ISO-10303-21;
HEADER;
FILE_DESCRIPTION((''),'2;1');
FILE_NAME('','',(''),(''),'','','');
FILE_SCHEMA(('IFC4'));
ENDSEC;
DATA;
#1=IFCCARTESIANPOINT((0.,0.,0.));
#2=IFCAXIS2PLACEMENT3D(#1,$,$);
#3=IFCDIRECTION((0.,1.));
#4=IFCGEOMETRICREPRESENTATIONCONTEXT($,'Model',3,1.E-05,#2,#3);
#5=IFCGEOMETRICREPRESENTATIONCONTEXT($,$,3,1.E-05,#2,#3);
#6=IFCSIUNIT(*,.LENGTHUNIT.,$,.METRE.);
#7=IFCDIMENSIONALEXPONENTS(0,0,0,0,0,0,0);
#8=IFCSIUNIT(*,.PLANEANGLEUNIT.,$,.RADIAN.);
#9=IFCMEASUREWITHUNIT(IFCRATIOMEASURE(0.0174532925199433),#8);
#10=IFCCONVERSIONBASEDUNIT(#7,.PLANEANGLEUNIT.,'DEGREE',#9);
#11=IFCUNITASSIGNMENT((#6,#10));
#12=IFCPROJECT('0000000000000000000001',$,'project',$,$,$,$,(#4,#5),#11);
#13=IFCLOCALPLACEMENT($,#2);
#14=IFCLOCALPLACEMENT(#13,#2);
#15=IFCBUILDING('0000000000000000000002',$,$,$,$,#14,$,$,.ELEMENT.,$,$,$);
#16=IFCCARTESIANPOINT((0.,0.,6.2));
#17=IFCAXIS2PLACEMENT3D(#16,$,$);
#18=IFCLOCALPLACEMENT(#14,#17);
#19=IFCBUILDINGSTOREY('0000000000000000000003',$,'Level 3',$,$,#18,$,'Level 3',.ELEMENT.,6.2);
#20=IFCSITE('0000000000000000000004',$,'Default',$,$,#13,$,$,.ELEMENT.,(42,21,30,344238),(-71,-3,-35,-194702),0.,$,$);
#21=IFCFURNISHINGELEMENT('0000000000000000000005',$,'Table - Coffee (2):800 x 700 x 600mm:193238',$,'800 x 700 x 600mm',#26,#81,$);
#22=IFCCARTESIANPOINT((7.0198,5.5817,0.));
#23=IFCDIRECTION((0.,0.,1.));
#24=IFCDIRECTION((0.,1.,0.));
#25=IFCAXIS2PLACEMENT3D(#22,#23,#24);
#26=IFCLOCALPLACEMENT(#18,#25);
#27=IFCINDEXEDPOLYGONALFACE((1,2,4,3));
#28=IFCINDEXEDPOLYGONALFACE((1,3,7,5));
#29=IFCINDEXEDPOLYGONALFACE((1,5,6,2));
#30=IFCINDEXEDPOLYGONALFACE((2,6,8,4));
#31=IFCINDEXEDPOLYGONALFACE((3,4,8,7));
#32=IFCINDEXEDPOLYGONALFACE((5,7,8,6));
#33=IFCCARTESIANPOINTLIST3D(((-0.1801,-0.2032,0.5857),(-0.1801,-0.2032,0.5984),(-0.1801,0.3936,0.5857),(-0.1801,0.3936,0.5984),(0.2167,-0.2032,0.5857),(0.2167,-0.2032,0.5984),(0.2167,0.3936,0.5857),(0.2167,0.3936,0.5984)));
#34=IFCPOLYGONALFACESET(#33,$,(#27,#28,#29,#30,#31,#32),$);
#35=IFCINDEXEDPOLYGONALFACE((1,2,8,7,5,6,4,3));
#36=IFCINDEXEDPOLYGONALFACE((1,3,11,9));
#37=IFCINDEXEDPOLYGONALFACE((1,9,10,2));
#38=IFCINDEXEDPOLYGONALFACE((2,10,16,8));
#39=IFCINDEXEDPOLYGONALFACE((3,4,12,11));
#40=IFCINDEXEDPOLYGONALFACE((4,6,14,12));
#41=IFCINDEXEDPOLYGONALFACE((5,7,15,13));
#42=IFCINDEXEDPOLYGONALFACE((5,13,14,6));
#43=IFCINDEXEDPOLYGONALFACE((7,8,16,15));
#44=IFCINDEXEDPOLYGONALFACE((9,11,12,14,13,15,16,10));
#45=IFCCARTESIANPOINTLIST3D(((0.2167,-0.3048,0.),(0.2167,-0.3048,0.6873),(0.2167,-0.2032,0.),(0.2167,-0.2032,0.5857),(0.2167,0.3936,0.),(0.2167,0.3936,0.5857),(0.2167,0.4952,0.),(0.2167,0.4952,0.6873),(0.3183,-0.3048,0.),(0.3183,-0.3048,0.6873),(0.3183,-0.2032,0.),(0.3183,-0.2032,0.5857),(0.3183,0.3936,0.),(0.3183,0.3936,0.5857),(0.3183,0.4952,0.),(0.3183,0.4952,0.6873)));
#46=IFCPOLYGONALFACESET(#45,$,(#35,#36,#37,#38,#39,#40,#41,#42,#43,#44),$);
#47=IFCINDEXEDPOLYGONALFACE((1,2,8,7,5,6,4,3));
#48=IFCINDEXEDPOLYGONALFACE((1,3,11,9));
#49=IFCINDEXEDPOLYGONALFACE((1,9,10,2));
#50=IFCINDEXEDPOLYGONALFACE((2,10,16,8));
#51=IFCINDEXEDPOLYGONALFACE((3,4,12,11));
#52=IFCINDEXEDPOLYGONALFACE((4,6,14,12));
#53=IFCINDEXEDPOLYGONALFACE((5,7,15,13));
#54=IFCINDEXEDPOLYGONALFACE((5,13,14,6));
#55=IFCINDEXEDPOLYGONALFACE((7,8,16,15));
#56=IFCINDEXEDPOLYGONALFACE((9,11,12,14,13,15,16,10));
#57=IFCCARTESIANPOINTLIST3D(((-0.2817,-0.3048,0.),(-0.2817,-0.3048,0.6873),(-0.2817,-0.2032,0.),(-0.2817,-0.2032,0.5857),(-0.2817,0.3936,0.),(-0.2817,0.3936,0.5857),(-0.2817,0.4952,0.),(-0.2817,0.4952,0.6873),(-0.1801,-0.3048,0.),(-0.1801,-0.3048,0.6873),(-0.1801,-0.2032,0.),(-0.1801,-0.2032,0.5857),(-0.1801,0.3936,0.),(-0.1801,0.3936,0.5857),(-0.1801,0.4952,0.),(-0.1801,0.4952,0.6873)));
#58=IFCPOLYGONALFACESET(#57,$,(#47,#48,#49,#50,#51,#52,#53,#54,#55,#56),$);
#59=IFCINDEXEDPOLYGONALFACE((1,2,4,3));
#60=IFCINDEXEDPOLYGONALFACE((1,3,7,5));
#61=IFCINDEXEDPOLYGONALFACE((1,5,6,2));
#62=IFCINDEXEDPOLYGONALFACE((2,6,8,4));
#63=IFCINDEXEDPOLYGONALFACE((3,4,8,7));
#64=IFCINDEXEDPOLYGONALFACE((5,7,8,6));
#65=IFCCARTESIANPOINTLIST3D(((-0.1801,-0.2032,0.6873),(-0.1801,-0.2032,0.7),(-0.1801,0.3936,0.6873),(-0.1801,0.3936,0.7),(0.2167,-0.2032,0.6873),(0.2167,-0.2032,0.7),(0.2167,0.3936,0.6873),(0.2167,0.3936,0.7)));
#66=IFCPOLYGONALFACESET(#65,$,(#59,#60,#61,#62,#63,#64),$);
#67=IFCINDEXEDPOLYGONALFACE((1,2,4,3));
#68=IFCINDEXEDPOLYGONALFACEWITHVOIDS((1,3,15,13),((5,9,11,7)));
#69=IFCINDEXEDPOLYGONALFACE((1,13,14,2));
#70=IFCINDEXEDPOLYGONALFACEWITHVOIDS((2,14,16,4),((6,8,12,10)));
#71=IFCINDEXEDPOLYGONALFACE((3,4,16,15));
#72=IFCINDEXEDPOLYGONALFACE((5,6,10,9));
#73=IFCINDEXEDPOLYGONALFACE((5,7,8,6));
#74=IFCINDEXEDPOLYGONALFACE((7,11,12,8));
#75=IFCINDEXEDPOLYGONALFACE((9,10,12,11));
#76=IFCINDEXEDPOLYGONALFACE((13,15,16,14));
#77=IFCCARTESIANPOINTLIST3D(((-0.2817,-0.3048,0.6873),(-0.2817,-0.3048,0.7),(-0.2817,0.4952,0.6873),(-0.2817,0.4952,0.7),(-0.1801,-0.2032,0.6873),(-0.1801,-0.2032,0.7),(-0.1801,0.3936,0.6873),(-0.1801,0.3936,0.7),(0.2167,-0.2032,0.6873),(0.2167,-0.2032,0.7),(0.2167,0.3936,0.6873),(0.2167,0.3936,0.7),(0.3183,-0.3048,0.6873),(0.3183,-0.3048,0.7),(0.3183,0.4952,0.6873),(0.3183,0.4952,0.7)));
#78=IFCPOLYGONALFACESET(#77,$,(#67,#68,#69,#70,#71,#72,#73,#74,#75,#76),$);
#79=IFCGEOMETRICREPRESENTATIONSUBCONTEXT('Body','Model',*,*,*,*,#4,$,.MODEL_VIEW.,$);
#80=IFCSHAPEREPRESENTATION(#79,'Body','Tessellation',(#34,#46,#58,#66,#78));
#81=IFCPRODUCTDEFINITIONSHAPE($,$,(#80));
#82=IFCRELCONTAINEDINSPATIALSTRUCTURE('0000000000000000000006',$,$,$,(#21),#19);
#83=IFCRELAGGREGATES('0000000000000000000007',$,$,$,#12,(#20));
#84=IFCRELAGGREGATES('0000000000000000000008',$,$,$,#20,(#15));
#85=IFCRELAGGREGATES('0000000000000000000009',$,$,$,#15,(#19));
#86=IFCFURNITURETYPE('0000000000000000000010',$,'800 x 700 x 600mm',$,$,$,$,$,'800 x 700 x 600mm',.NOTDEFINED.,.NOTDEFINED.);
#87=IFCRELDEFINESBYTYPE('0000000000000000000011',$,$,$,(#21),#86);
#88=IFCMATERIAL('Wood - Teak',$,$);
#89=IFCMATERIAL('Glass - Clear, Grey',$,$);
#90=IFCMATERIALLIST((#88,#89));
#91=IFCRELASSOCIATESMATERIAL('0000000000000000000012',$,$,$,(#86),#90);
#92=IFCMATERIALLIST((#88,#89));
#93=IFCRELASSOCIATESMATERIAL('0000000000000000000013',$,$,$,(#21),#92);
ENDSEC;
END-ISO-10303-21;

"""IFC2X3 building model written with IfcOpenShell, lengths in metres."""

from ifc_helpers import new_model, entity, si_unit, converted_unit, direction, frame, frame_2d, origin, origin_2d_with_axis, place, context, subcontext, project, spatial, polyline, rectangle, outline, extrude, source, transform, mapped, material, material_list, type_object, type_shapes, element, save


model = new_model("IFC2X3")

# Units and contexts
model_context = context("Model", 3, precision=1e-05, world=origin(), true_north=direction((0.0, 1.0)))
context_of_model = context(None, 3, precision=1e-05, world=origin(), true_north=direction((0.0, 1.0)))
body_context = subcontext(model_context, "Body", "Model", "MODEL_VIEW")
ifc_project = project(units=[si_unit("LENGTHUNIT", "METRE"), converted_unit("PLANEANGLEUNIT", "DEGREE", entity("IfcRatioMeasure", 0.0174532925199433), si_unit("PLANEANGLEUNIT", "RADIAN"), dimensions=[0, 0, 0, 0, 0, 0, 0])], contexts=[model_context, context_of_model])

# Site, building, storey
site_placement = place(None, origin())
site = spatial("IfcSite", under=ifc_project, at=site_placement, Name="Default", CompositionType="ELEMENT", RefLatitude=(42, 21, 30, 344238), RefLongitude=(-71, -3, -35, -194702), RefElevation=0.0)
building_placement = place(site_placement, origin())
building = spatial("IfcBuilding", under=site, at=building_placement, CompositionType="ELEMENT")
storey_placement = place(building_placement, frame((0.0, 0.0, 6.2)))
storey = spatial("IfcBuildingStorey", under=building, at=storey_placement, Name="Level 3", LongName="Level 3", CompositionType="ELEMENT", Elevation=6.2)

# Furnishing element
ifc_material_1 = material(Name="Wood - Teak")
ifc_material_2 = material(Name="Glass - Clear, Grey")
ifc_material_list_1 = material_list([ifc_material_1, ifc_material_2])
furniture_type_1 = type_object("IfcFurnitureType", Name="800 x 700 x 600mm", ElementType="800 x 700 x 600mm", AssemblyPlace="NOTDEFINED", material=ifc_material_list_1)
shared_shape_1 = source(origin(), body_context, "Body", "SweptSolid", [
    extrude(rectangle(XDim=0.3968, YDim=0.5968, at=origin_2d_with_axis()), frame((0.0183, 0.0952, 0.5857), z_axis=(0.0, 0.0, 1.0), x_axis=(-1.0, 0.0, 0.0)), (0.0, 0.0, 1.0), 0.0127),
    extrude(outline(polyline([(-0.3182, -0.4), (0.369, -0.4), (0.369, 0.4), (-0.3182, 0.4), (-0.3182, 0.2984), (0.2675, 0.2984), (0.2675, -0.2984), (-0.3182, -0.2984), (-0.3182, -0.4)])), frame((0.2167, 0.0952, 0.3182), z_axis=(1.0, 0.0, 0.0), x_axis=(0.0, 0.0, 1.0)), (0.0, 0.0, 1.0), 0.1016),
    extrude(outline(polyline([(-0.4, -0.3691), (0.4, -0.3691), (0.4, 0.3183), (0.2984, 0.3183), (0.2984, -0.2674), (-0.2984, -0.2674), (-0.2984, 0.3183), (-0.4, 0.3183), (-0.4, -0.3691)])), frame((-0.2817, 0.0952, 0.3183), z_axis=(1.0, 0.0, 0.0), x_axis=(0.0, -1.0, 0.0)), (0.0, 0.0, 1.0), 0.1016),
    extrude(rectangle(XDim=0.3968, YDim=0.5968, at=frame_2d((0.0, 0.0), x_axis=(1.0, 0.0))), frame((0.0183, 0.0952, 0.6873), z_axis=(0.0, 0.0, 1.0), x_axis=(-1.0, 0.0, 0.0)), (0.0, 0.0, 1.0), 0.0127),
    extrude(outline(polyline([(-0.3, -0.4), (0.3, -0.4), (0.3, 0.4), (-0.3, 0.4), (-0.3, -0.4)]), holes=[polyline([(-0.1984, -0.2984), (-0.1984, 0.2984), (0.1984, 0.2984), (0.1984, -0.2984), (-0.1984, -0.2984)])]), frame((0.0183, 0.0952, 0.6873), z_axis=(0.0, 0.0, 1.0), x_axis=(-1.0, 0.0, 0.0)), (0.0, 0.0, 1.0), 0.0127),
])
type_shapes(furniture_type_1, [shared_shape_1])
ifc_material_list_2 = material_list([ifc_material_1, ifc_material_2])
furnishing_1_placement = place(storey_placement, frame((7.0198, 5.5817, 0.0), z_axis=(0.0, 0.0, 1.0), x_axis=(0.0, 1.0, 0.0)))
element("IfcFurnishingElement", 1, at=furnishing_1_placement, inside=storey, type_object=furniture_type_1, material=ifc_material_list_2, Name="Table - Coffee (2):800 x 700 x 600mm:193238", ObjectType="800 x 700 x 600mm", context=body_context, shape_type="MappedRepresentation", body=[
    mapped(shared_shape_1, transform((0.0, 0.0, 0.0), scale=1.0)),
])

save(model, "model.ifc")
